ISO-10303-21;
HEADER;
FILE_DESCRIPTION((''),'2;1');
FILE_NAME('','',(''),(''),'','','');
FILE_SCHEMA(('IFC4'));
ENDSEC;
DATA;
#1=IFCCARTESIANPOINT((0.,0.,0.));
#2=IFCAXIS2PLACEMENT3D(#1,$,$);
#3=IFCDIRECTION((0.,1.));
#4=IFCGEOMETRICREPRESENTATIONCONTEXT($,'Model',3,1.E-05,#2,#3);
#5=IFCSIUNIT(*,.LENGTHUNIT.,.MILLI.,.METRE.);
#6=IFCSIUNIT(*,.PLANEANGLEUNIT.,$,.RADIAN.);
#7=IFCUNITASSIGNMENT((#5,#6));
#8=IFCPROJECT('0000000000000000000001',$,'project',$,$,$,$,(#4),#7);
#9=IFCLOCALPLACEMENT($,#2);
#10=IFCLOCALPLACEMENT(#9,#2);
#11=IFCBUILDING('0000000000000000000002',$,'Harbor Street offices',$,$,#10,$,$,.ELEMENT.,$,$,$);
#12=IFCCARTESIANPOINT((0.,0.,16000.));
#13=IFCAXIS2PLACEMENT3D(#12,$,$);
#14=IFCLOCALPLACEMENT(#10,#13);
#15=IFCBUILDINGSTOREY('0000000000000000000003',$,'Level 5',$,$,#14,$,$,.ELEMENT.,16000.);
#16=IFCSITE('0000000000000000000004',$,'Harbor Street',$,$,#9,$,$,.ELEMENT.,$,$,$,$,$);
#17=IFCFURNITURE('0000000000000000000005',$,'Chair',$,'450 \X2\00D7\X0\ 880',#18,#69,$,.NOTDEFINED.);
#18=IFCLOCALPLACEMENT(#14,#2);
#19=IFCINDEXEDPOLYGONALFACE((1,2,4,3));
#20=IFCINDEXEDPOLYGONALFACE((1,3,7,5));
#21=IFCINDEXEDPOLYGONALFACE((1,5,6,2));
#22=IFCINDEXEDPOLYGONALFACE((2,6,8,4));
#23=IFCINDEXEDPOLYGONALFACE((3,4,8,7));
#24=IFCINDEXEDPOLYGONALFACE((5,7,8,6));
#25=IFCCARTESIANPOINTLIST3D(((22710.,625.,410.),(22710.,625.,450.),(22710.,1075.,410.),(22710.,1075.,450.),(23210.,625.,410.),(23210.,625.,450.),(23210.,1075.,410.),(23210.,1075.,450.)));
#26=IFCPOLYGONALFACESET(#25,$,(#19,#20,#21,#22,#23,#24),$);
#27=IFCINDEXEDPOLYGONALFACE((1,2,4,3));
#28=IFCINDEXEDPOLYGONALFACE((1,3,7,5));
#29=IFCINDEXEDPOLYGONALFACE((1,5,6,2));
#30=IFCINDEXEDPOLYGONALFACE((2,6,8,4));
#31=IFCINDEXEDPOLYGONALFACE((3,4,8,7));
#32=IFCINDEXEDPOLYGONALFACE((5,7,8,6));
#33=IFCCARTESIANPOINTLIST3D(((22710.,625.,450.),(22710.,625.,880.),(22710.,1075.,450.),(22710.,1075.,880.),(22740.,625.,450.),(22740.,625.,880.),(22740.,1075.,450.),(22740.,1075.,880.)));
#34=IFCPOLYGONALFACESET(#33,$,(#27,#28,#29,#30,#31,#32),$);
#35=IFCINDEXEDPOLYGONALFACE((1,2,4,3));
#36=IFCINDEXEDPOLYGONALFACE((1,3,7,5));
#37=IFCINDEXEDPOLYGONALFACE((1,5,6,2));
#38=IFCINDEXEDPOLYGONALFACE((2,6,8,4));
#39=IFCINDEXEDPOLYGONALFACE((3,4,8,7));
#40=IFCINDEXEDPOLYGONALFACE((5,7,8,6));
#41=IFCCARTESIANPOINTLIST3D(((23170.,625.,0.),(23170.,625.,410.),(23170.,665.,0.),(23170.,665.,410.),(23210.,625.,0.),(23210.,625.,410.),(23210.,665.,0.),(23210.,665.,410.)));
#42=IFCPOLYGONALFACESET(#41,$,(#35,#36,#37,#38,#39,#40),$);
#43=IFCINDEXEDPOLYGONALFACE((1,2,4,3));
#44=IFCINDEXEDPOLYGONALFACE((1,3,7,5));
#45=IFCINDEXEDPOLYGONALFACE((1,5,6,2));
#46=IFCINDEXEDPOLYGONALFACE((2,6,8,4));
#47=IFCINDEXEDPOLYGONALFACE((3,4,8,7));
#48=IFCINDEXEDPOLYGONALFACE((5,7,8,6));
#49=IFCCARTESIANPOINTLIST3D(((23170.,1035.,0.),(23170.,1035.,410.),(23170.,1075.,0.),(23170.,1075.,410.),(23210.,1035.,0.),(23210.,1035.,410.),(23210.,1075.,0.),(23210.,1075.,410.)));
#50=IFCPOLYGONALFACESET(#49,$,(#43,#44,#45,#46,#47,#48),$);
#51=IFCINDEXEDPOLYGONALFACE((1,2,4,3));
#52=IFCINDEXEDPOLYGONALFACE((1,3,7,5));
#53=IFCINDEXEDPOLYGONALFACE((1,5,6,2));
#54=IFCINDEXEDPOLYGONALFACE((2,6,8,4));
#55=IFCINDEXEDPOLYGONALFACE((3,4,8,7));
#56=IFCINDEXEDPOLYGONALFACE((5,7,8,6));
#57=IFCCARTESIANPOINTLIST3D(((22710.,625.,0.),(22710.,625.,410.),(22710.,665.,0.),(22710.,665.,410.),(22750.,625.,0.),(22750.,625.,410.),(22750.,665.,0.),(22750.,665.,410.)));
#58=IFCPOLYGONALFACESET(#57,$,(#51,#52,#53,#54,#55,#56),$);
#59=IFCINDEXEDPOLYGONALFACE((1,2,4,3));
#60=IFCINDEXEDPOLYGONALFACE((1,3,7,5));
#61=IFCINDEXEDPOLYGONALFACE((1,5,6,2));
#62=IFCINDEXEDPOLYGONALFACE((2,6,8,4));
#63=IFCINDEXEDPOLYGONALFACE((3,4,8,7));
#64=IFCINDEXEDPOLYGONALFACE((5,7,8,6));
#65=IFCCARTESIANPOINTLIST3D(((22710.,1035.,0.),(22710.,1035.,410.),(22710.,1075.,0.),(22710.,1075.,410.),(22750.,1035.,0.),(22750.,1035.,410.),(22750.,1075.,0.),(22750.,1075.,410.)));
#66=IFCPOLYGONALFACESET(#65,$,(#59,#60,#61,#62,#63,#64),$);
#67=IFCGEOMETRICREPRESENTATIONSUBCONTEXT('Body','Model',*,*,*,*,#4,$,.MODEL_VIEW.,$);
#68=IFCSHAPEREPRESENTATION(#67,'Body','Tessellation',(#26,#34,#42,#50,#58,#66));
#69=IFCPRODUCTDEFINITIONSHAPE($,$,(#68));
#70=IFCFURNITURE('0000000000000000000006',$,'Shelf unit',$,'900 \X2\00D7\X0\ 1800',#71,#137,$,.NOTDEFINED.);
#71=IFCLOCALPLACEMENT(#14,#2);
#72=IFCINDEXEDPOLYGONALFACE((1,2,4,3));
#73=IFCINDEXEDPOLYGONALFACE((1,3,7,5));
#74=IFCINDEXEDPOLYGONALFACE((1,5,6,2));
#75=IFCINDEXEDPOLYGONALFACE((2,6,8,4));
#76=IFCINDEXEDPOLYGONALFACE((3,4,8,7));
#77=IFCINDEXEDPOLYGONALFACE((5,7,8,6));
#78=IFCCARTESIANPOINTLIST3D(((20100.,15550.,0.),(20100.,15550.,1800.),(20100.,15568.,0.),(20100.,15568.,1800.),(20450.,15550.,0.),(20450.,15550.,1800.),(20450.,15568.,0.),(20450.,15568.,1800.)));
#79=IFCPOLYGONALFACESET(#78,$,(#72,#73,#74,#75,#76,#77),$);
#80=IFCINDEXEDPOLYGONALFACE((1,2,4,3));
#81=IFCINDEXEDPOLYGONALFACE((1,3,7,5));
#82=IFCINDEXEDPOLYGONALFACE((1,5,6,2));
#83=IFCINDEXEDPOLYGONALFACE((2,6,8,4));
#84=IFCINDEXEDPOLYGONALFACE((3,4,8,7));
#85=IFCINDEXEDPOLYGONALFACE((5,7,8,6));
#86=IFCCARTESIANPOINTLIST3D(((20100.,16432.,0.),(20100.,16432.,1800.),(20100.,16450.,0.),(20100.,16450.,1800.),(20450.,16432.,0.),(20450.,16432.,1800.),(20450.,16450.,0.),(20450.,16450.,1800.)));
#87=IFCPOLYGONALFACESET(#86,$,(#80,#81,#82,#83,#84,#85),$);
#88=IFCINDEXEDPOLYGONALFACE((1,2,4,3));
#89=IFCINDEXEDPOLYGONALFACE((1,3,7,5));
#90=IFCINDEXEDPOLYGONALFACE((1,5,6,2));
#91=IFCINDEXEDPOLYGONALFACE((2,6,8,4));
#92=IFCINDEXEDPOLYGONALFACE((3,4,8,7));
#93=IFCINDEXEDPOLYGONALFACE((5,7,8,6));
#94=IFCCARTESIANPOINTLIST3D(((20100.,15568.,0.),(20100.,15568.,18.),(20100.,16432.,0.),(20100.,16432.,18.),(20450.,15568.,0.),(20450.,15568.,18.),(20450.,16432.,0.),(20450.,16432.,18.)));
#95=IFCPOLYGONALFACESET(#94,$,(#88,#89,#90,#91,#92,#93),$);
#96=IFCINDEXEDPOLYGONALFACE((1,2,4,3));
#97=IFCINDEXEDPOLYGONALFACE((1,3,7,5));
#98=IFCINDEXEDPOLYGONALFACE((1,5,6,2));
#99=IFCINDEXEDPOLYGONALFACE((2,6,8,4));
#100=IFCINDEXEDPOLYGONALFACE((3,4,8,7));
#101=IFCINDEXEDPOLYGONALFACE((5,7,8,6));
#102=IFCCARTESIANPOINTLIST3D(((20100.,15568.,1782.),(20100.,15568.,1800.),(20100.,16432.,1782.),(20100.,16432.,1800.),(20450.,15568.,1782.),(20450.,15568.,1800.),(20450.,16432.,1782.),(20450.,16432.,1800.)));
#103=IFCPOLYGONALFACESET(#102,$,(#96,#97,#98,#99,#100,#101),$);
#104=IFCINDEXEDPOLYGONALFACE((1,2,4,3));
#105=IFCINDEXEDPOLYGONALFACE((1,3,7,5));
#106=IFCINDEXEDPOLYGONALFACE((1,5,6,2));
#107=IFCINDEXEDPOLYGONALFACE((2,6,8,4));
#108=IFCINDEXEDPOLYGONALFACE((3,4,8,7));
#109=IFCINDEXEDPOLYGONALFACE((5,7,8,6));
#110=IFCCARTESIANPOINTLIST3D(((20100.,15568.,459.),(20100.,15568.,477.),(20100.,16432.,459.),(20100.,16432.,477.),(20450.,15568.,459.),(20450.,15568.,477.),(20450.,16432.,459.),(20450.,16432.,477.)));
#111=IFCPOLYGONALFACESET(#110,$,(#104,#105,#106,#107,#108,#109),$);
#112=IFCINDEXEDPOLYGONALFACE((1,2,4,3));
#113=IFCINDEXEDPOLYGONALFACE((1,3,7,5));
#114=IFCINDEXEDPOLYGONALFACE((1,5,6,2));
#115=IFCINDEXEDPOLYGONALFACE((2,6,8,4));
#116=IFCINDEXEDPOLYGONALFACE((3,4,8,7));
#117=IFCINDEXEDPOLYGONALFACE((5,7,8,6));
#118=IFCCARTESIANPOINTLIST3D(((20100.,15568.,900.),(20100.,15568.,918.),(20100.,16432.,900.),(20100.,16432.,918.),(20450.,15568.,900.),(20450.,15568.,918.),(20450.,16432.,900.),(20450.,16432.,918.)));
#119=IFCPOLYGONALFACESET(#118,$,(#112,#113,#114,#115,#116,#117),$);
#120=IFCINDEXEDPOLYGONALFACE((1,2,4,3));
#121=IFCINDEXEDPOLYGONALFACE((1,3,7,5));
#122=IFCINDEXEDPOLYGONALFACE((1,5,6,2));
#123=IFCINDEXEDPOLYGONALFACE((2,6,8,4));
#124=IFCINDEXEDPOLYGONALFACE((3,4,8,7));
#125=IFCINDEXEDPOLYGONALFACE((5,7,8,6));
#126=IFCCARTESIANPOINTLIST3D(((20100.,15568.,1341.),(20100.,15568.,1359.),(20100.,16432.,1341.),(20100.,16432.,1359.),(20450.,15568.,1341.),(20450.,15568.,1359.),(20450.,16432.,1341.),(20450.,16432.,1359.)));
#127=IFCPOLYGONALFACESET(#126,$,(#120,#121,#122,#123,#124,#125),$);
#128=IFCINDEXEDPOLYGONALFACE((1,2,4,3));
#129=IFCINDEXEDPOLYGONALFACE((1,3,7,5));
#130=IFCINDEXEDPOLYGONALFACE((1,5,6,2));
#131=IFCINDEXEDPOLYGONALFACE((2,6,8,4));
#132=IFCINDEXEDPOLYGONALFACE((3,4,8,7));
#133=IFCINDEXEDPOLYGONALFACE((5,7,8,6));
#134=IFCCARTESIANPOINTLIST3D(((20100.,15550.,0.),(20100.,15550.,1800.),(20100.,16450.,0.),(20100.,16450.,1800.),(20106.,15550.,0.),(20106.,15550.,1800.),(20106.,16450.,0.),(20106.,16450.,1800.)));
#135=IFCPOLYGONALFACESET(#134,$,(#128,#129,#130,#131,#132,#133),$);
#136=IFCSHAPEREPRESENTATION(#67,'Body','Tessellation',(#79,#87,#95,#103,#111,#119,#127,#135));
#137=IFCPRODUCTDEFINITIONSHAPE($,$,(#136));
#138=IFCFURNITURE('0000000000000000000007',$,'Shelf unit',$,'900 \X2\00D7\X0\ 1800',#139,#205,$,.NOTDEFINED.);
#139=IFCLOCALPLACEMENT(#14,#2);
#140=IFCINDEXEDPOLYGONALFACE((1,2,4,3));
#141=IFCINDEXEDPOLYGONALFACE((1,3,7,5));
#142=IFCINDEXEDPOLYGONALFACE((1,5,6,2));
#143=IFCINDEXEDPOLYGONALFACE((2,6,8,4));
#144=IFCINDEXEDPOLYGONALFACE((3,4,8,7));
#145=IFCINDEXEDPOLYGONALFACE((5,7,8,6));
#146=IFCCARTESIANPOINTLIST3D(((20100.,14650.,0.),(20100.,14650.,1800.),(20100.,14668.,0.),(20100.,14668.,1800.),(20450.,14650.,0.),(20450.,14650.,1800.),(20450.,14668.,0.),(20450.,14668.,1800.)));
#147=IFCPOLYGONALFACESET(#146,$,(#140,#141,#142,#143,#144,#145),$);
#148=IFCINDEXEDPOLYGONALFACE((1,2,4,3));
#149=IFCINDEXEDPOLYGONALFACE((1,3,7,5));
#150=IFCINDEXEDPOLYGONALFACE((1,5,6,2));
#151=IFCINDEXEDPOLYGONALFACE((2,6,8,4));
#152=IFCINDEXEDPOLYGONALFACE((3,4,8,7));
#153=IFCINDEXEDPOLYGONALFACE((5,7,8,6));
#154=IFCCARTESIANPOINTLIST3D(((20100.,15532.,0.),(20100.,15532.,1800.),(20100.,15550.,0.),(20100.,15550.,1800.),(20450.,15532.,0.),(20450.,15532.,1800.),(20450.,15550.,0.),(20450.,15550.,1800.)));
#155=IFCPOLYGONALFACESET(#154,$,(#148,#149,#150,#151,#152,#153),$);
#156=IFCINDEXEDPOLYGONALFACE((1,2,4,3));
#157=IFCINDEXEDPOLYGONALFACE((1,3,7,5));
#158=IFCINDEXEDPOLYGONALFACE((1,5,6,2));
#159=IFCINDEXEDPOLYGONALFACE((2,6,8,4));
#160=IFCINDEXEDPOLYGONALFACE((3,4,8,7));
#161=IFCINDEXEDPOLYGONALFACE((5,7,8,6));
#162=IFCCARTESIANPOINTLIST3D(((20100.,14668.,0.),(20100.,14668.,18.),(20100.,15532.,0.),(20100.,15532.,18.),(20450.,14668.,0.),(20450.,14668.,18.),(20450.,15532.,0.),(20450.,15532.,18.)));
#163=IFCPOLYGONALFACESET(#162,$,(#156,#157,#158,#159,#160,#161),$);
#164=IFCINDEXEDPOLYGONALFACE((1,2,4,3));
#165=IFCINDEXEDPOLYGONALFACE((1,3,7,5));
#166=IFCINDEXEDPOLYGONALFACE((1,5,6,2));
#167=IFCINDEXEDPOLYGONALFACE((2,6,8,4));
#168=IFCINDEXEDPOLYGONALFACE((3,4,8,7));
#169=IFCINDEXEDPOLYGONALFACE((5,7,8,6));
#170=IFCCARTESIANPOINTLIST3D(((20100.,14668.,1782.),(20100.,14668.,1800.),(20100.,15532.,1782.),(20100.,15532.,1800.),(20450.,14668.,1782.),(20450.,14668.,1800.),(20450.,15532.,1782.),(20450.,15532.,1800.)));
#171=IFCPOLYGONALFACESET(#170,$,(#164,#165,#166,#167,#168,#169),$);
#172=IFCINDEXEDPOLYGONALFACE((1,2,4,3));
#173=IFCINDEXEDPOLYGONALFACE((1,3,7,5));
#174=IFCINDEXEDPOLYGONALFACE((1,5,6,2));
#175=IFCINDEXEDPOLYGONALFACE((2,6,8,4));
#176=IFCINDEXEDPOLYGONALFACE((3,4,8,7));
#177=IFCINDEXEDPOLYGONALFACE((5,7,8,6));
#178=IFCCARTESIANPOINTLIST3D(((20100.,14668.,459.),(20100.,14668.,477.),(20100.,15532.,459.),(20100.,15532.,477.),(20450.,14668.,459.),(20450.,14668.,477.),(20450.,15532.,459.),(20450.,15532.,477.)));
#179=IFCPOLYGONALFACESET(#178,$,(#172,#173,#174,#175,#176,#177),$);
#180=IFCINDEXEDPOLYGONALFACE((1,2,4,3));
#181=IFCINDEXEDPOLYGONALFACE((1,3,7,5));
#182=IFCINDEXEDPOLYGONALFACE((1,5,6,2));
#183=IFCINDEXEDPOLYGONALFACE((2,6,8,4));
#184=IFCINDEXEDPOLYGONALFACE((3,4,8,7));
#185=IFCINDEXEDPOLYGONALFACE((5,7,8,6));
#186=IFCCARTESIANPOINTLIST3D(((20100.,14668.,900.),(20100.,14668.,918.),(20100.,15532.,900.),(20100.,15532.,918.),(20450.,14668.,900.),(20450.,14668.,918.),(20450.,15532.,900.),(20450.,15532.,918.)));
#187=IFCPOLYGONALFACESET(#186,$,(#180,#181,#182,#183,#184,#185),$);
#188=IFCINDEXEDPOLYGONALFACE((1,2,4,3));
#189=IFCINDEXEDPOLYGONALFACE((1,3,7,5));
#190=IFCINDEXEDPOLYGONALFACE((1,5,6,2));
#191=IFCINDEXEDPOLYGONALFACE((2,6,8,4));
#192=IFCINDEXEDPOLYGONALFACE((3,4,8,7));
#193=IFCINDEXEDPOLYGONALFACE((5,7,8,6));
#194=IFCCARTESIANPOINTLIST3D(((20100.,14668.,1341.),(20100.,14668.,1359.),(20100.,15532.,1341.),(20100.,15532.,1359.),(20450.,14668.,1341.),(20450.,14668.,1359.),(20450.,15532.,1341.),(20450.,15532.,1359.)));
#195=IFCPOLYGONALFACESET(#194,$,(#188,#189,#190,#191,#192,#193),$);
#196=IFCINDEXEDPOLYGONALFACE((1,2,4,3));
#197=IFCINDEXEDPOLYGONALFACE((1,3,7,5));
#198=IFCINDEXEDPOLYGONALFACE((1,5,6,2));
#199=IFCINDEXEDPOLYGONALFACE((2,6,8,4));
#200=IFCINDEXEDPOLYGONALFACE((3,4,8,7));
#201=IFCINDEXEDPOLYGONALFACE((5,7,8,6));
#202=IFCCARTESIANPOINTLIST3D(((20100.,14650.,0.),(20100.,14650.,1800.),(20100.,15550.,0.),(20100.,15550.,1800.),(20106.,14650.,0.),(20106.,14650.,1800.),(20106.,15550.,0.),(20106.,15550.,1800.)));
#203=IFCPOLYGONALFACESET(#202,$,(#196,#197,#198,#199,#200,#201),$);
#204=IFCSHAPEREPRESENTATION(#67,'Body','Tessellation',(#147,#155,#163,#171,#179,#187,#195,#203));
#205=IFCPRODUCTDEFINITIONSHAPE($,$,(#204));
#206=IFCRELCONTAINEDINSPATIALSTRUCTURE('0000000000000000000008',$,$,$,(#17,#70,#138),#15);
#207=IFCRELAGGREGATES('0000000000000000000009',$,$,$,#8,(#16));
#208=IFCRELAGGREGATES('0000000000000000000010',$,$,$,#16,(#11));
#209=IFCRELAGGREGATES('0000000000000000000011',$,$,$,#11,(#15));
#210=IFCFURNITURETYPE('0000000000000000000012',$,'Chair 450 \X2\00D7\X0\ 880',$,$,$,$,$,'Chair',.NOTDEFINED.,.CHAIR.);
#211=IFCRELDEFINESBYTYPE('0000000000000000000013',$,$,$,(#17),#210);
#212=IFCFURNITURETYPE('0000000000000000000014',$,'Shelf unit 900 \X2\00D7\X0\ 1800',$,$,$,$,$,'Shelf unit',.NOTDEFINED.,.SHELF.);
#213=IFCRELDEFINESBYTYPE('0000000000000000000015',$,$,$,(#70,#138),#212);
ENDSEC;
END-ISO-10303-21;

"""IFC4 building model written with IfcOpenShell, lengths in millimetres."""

from ifc_helpers import new_model, si_unit, direction, frame, origin, place, context, subcontext, project, spatial, polyline, outline, extrude, source, transform, mapped, type_object, type_shapes, element, save


model = new_model("IFC4")

# Units and contexts
model_context = context("Model", 3, precision=1e-05, world=origin(), true_north=direction((0.0, 1.0)))
body_context = subcontext(model_context, "Body", "Model", "MODEL_VIEW")
ifc_project = project(units=[si_unit("LENGTHUNIT", "METRE", prefix="MILLI"), si_unit("PLANEANGLEUNIT", "RADIAN")], contexts=[model_context])

# Site, building, storey
site_placement = place(None, origin())
site = spatial("IfcSite", under=ifc_project, at=site_placement, Name="Harbor Street", CompositionType="ELEMENT")
building_placement = place(site_placement, origin())
building = spatial("IfcBuilding", under=site, at=building_placement, Name="Harbor Street offices", CompositionType="ELEMENT")
storey_placement = place(building_placement, frame((0.0, 0.0, 16000.0)))
storey = spatial("IfcBuildingStorey", under=building, at=storey_placement, Name="Level 5", CompositionType="ELEMENT", Elevation=16000.0)

# Furniture
furniture_type_1 = type_object("IfcFurnitureType", Name="Chair 450 × 880", ElementType="Chair", AssemblyPlace="NOTDEFINED", PredefinedType="CHAIR")
shared_shape_1 = source(origin(), body_context, "Body", "SweptSolid", [
    extrude(outline(polyline([(-225.0, 0.0), (225.0, 0.0), (225.0, 500.0), (-225.0, 500.0), (-225.0, 0.0)])), frame((0.0, 0.0, 410.0)), (0.0, 0.0, 1.0), 40.0),
    extrude(outline(polyline([(-225.0, 470.0), (225.0, 470.0), (225.0, 500.0), (-225.0, 500.0), (-225.0, 470.0)])), frame((0.0, 0.0, 450.0)), (0.0, 0.0, 1.0), 430.0),
    extrude(outline(polyline([(-225.0, 0.0), (-185.0, 0.0), (-185.0, 40.0), (-225.0, 40.0), (-225.0, 0.0)])), origin(), (0.0, 0.0, 1.0), 410.0),
    extrude(outline(polyline([(185.0, 0.0), (225.0, 0.0), (225.0, 40.0), (185.0, 40.0), (185.0, 0.0)])), origin(), (0.0, 0.0, 1.0), 410.0),
    extrude(outline(polyline([(-225.0, 460.0), (-185.0, 460.0), (-185.0, 500.0), (-225.0, 500.0), (-225.0, 460.0)])), origin(), (0.0, 0.0, 1.0), 410.0),
    extrude(outline(polyline([(185.0, 460.0), (225.0, 460.0), (225.0, 500.0), (185.0, 500.0), (185.0, 460.0)])), origin(), (0.0, 0.0, 1.0), 410.0),
])
type_shapes(furniture_type_1, [shared_shape_1])
for number, where, z_axis, x_axis, name in (
    (1, (23210.0, 850.0, 0.0), (0.0, 0.0, 1.0), (0.0, 1.0, 0.0), "Chair"),
):
    element("IfcFurniture", number, at=place(storey_placement, frame(where, z_axis=z_axis, x_axis=x_axis)), inside=storey, type_object=furniture_type_1, Name=name, ObjectType="450 × 880", PredefinedType="NOTDEFINED", context=body_context, shape_type="MappedRepresentation", body=[
        mapped(shared_shape_1, transform((0.0, 0.0, 0.0))),
    ])
furniture_type_2 = type_object("IfcFurnitureType", Name="Shelf unit 900 × 1800", ElementType="Shelf unit", AssemblyPlace="NOTDEFINED", PredefinedType="SHELF")
shared_shape_2 = source(origin(), body_context, "Body", "SweptSolid", [
    extrude(outline(polyline([(-450.0, 0.0), (-432.0, 0.0), (-432.0, 350.0), (-450.0, 350.0), (-450.0, 0.0)])), origin(), (0.0, 0.0, 1.0), 1800.0),
    extrude(outline(polyline([(432.0, 0.0), (450.0, 0.0), (450.0, 350.0), (432.0, 350.0), (432.0, 0.0)])), origin(), (0.0, 0.0, 1.0), 1800.0),
    extrude(outline(polyline([(-432.0, 0.0), (432.0, 0.0), (432.0, 350.0), (-432.0, 350.0), (-432.0, 0.0)])), origin(), (0.0, 0.0, 1.0), 18.0),
    extrude(outline(polyline([(-432.0, 0.0), (432.0, 0.0), (432.0, 350.0), (-432.0, 350.0), (-432.0, 0.0)])), frame((0.0, 0.0, 1782.0)), (0.0, 0.0, 1.0), 18.0),
    extrude(outline(polyline([(-432.0, 0.0), (432.0, 0.0), (432.0, 350.0), (-432.0, 350.0), (-432.0, 0.0)])), frame((0.0, 0.0, 459.0)), (0.0, 0.0, 1.0), 18.0),
    extrude(outline(polyline([(-432.0, 0.0), (432.0, 0.0), (432.0, 350.0), (-432.0, 350.0), (-432.0, 0.0)])), frame((0.0, 0.0, 900.0)), (0.0, 0.0, 1.0), 18.0),
    extrude(outline(polyline([(-432.0, 0.0), (432.0, 0.0), (432.0, 350.0), (-432.0, 350.0), (-432.0, 0.0)])), frame((0.0, 0.0, 1341.0)), (0.0, 0.0, 1.0), 18.0),
    extrude(outline(polyline([(-450.0, 344.0), (450.0, 344.0), (450.0, 350.0), (-450.0, 350.0), (-450.0, 344.0)])), origin(), (0.0, 0.0, 1.0), 1800.0),
])
type_shapes(furniture_type_2, [shared_shape_2])
for number, where, z_axis, x_axis, name in (
    (2, (20450.0, 16000.0, 0.0), (0.0, 0.0, 1.0), (0.0, 1.0, 0.0), "Shelf unit"),
    (3, (20450.0, 15100.0, 0.0), (0.0, 0.0, 1.0), (0.0, 1.0, 0.0), "Shelf unit"),
):
    element("IfcFurniture", number, at=place(storey_placement, frame(where, z_axis=z_axis, x_axis=x_axis)), inside=storey, type_object=furniture_type_2, Name=name, ObjectType="900 × 1800", PredefinedType="NOTDEFINED", context=body_context, shape_type="MappedRepresentation", body=[
        mapped(shared_shape_2, transform((0.0, 0.0, 0.0))),
    ])

save(model, "model.ifc")
